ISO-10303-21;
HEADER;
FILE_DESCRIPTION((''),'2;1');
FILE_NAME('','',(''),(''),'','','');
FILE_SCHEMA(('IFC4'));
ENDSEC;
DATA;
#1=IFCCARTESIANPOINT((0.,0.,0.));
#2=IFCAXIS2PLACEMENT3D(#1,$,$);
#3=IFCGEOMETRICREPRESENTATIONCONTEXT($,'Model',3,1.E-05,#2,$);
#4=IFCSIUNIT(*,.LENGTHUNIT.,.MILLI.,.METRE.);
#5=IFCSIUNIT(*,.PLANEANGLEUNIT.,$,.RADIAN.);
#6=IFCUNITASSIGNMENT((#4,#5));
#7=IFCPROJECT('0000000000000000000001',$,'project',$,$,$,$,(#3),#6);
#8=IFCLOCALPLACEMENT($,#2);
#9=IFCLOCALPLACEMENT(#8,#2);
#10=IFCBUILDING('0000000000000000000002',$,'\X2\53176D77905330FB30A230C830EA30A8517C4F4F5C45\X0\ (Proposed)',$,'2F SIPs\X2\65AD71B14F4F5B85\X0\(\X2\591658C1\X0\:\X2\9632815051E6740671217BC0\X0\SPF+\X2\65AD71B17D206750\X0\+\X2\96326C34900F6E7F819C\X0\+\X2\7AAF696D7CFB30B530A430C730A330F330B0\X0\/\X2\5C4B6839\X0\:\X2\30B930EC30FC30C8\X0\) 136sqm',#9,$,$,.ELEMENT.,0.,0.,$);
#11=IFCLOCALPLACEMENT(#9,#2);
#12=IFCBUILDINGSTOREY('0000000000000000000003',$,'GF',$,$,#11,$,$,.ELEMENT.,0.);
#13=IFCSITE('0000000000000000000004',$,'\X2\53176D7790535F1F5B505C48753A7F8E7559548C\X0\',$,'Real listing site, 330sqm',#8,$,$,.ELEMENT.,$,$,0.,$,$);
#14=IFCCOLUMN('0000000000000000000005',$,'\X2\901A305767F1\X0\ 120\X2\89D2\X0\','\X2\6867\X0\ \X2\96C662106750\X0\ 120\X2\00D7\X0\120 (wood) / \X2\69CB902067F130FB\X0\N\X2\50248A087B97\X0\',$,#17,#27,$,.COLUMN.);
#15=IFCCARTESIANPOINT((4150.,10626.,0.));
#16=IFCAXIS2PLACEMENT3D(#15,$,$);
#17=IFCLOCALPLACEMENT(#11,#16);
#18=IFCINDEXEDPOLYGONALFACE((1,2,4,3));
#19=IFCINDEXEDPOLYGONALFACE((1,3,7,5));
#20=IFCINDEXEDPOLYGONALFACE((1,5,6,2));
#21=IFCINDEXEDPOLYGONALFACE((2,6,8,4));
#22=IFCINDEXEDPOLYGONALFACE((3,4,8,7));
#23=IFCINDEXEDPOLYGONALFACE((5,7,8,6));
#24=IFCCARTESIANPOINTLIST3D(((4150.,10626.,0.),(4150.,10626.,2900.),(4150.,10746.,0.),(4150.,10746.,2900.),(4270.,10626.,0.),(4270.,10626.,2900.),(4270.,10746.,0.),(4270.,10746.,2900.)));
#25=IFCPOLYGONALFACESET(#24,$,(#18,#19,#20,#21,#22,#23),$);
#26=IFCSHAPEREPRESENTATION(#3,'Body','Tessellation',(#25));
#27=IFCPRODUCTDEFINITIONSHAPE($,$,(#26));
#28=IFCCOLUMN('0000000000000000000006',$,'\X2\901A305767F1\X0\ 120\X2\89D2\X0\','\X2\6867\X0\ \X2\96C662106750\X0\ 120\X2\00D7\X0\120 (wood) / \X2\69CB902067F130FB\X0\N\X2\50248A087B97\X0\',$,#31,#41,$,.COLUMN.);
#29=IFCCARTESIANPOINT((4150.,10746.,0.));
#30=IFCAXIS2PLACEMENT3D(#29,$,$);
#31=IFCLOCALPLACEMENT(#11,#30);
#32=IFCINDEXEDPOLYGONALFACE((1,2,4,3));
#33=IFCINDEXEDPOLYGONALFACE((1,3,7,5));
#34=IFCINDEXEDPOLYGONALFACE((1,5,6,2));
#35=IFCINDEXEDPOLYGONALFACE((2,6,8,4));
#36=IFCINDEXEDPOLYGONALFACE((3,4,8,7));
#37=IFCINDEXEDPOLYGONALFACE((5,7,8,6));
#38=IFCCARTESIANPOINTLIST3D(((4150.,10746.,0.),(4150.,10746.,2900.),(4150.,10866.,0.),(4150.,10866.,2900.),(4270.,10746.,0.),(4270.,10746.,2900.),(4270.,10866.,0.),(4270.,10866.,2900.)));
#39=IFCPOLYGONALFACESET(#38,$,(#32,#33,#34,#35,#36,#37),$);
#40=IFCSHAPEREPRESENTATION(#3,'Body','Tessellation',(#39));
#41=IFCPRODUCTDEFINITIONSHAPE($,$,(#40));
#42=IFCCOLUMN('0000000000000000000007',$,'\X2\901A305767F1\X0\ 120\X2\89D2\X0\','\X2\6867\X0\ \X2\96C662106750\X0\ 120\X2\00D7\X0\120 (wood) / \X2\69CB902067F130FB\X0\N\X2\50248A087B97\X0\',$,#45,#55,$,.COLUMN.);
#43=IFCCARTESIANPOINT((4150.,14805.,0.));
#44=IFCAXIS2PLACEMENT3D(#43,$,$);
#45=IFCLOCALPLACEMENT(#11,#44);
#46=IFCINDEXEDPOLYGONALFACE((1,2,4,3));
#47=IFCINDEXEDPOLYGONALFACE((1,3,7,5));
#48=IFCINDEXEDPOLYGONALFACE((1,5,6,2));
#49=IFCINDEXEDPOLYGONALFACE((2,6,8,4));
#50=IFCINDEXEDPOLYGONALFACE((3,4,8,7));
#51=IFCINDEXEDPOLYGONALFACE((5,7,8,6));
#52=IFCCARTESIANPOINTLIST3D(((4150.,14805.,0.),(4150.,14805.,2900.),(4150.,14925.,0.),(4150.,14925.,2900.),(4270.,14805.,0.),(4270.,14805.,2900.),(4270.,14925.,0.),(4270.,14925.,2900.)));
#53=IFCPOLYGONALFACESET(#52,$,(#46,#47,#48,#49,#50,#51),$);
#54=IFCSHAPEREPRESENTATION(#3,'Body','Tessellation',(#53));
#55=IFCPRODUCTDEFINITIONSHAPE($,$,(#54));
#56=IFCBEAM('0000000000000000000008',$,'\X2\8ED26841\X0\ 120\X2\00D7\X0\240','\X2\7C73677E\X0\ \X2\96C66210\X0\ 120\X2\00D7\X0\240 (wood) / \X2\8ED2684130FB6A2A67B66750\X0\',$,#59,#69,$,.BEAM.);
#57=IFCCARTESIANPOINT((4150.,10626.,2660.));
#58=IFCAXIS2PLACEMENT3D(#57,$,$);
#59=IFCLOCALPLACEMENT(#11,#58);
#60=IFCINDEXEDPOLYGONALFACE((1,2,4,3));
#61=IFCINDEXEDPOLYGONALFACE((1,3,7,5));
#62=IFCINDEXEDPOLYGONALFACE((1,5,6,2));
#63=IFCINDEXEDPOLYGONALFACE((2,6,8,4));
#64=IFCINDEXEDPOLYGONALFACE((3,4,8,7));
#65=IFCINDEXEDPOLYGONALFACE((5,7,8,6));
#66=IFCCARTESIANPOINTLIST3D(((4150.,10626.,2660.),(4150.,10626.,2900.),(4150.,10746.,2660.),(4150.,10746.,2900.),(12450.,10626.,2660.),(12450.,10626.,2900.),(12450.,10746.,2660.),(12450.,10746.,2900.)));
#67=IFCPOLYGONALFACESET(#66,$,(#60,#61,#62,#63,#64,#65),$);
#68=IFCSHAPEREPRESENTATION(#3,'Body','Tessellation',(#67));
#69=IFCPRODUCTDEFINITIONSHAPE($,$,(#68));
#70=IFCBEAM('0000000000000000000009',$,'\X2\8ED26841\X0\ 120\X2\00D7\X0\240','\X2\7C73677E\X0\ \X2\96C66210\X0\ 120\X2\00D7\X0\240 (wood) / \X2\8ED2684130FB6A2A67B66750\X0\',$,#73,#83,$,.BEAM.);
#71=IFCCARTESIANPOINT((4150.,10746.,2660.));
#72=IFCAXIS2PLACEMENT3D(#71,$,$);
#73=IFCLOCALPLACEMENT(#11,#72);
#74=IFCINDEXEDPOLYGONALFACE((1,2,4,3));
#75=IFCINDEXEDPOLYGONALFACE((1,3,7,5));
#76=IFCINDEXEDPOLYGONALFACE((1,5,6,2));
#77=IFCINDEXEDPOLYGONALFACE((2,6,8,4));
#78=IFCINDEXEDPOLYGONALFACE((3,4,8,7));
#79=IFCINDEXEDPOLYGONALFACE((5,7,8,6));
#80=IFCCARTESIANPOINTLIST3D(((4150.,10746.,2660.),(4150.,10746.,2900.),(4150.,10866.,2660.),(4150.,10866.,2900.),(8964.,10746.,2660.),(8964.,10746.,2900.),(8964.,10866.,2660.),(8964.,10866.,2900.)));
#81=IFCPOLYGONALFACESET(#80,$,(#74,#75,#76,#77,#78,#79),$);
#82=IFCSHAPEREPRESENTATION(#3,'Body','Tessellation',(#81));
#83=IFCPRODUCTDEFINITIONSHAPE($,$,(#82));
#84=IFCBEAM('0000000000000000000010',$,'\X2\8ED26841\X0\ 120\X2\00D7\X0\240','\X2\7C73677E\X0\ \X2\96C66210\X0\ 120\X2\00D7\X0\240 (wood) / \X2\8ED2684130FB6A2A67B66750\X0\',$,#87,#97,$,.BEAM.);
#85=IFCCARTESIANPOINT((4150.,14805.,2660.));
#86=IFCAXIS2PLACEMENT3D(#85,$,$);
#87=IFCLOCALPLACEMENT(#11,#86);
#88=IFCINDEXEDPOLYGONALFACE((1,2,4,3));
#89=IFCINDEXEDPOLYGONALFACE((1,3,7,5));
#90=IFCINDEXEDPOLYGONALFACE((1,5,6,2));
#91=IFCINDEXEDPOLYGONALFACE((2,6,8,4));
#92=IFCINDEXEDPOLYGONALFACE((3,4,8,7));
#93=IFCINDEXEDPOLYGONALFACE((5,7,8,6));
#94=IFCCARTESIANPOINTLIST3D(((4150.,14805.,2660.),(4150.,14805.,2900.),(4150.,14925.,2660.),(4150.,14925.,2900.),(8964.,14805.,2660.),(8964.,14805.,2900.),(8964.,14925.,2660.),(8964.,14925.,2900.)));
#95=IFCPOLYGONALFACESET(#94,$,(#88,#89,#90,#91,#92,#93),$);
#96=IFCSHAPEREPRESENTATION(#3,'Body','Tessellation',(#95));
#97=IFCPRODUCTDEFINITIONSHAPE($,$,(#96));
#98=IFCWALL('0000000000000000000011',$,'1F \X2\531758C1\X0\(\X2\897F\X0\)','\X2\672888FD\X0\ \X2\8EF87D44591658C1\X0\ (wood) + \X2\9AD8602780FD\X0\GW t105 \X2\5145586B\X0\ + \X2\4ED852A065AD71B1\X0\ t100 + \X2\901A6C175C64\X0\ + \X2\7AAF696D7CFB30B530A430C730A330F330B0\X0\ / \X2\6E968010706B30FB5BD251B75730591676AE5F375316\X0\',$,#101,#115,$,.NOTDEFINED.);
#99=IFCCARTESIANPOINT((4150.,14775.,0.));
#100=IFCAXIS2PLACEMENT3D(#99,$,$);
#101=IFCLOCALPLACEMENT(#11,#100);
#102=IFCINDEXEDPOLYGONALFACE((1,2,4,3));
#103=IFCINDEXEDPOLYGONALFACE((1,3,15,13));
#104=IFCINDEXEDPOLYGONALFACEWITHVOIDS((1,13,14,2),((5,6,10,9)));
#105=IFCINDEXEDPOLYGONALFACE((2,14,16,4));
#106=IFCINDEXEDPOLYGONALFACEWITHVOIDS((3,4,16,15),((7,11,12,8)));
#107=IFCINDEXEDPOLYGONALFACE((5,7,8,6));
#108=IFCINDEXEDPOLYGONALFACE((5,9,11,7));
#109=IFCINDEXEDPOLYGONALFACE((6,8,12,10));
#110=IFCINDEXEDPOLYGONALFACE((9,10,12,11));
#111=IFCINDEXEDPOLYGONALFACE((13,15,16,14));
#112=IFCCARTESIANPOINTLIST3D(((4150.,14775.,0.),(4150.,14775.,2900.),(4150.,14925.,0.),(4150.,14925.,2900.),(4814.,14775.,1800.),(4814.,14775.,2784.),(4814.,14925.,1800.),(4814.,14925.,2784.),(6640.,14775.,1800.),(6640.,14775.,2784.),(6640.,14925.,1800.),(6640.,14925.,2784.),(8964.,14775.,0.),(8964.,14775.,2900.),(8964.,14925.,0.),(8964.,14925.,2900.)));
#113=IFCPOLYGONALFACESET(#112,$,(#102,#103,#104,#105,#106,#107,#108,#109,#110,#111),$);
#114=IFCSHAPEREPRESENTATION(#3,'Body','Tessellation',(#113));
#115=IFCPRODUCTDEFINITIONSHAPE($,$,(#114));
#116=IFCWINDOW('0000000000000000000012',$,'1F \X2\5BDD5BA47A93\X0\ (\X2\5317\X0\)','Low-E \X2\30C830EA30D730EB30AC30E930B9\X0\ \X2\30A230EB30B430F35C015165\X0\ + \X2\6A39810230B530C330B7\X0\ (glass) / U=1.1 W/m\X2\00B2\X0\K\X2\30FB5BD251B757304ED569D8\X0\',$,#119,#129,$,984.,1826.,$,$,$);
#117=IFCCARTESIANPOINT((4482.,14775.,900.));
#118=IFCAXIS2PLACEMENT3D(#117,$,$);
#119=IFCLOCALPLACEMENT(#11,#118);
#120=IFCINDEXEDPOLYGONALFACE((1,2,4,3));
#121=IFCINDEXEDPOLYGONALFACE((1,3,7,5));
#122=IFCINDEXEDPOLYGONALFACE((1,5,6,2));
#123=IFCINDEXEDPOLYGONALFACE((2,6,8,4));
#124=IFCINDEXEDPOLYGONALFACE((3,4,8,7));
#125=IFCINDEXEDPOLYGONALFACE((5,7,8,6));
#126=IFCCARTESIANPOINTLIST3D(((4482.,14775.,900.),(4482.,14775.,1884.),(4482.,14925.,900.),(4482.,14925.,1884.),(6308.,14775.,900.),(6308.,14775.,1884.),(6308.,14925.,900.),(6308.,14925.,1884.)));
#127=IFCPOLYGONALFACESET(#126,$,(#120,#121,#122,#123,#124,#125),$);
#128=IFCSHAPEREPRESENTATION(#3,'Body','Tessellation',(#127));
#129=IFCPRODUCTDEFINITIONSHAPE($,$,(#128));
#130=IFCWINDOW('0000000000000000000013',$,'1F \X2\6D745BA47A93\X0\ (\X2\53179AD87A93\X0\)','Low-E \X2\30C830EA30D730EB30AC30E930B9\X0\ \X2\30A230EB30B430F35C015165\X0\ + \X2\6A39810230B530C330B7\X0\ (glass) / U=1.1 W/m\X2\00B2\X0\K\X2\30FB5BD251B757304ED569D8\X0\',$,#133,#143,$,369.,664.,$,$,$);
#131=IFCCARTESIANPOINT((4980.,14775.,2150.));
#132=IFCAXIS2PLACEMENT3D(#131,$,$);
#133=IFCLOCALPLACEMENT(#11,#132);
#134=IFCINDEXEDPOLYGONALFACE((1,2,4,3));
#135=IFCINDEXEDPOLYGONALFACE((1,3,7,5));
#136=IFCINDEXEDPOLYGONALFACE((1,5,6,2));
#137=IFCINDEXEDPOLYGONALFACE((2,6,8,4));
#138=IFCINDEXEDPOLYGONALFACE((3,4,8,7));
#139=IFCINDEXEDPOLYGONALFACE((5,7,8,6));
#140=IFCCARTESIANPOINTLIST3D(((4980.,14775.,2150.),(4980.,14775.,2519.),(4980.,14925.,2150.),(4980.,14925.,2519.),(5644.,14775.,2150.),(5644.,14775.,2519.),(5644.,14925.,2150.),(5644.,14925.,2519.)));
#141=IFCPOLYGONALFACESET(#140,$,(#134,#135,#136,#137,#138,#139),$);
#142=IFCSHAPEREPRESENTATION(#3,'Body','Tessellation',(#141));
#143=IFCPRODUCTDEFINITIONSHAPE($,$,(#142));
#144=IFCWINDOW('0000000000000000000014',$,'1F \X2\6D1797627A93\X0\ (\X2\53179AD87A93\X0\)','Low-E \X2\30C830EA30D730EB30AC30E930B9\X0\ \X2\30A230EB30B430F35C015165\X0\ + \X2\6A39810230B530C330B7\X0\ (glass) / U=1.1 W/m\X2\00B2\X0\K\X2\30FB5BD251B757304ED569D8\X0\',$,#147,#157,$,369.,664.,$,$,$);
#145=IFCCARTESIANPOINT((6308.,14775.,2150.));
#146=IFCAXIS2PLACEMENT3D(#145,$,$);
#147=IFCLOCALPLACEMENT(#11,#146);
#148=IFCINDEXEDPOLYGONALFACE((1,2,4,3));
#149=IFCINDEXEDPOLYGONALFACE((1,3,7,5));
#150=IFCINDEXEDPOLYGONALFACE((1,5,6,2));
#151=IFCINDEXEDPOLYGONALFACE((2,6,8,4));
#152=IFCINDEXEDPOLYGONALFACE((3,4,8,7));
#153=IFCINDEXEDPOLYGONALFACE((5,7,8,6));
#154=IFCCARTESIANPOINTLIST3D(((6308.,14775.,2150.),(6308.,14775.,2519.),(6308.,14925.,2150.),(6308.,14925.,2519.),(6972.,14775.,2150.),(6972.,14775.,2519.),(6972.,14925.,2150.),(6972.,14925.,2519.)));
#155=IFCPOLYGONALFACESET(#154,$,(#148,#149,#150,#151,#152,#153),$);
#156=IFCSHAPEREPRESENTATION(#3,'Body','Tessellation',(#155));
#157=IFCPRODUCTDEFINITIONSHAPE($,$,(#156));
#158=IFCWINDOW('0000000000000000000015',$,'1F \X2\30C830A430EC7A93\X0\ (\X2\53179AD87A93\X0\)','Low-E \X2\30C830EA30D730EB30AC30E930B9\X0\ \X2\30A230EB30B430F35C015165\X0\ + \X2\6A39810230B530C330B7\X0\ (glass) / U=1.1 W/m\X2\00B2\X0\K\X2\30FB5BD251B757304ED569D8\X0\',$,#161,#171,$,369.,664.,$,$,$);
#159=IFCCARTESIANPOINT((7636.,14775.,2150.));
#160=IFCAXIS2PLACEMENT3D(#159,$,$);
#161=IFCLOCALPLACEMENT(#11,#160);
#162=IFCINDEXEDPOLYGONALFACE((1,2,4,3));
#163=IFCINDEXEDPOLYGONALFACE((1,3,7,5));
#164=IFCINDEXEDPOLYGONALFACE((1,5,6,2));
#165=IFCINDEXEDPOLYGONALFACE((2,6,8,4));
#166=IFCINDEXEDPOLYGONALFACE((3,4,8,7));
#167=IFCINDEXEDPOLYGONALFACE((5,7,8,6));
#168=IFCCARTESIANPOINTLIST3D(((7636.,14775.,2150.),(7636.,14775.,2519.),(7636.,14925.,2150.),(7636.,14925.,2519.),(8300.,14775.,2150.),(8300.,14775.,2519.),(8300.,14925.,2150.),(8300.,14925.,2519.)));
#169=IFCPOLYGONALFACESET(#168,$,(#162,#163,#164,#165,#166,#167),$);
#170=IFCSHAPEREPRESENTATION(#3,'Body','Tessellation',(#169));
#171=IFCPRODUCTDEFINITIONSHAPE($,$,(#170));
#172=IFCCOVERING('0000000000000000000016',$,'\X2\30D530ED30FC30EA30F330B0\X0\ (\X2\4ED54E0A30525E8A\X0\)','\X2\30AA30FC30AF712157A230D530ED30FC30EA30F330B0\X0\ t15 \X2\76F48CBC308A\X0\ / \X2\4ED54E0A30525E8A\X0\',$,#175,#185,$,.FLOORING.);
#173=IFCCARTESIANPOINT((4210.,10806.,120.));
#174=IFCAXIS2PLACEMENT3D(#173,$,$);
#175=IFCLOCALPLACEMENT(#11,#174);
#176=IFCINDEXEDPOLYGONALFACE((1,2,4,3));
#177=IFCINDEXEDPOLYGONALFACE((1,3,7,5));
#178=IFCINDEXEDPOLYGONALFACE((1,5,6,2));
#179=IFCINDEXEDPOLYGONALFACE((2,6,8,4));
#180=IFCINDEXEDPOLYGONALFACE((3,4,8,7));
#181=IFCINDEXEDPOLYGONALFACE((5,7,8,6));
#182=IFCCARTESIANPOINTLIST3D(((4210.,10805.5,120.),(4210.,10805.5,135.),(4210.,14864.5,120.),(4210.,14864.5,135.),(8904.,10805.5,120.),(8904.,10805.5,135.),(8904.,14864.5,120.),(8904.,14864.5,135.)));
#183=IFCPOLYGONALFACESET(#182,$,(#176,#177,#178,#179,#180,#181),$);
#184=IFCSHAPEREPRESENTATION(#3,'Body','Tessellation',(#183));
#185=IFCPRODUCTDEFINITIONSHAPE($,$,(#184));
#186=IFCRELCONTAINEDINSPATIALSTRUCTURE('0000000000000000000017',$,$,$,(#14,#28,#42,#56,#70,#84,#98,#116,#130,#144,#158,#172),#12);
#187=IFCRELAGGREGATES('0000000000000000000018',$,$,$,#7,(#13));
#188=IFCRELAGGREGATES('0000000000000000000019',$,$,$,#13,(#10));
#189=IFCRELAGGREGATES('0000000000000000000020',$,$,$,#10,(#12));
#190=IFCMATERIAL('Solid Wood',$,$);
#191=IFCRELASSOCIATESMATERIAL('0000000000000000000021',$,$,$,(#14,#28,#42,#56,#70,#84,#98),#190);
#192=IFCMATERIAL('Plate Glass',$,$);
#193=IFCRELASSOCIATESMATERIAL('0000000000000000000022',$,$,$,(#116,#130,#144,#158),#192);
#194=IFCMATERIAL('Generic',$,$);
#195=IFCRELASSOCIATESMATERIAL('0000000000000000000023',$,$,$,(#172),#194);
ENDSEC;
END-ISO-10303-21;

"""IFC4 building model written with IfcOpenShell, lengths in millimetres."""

from ifc_helpers import new_model, si_unit, frame, frame_2d, origin, place, context, project, spatial, rectangle, extrude, material, element, fill, save


model = new_model("IFC4")

# Units and contexts
model_context = context("Model", 3, precision=1e-05, world=origin())
ifc_project = project(units=[si_unit("LENGTHUNIT", "METRE", prefix="MILLI"), si_unit("PLANEANGLEUNIT", "RADIAN")], contexts=[model_context])

# Site, building, storey
site_placement = place(None, origin())
site = spatial("IfcSite", under=ifc_project, at=site_placement, Name="北海道弟子屈町美留和", ObjectType="Real listing site, 330sqm", CompositionType="ELEMENT", RefElevation=0.0)
building_placement = place(site_placement, origin())
building = spatial("IfcBuilding", under=site, at=building_placement, Name="北海道・アトリエ兼住居 (Proposed)", ObjectType="2F SIPs断熱住宅(外壁:防腐処理無節SPF+断熱素材+防水透湿膜+窯業系サイディング/屋根:スレート) 136sqm", CompositionType="ELEMENT", ElevationOfRefHeight=0.0, ElevationOfTerrain=0.0)
storey_placement = place(building_placement, origin())
storey = spatial("IfcBuildingStorey", under=building, at=storey_placement, Name="GF", CompositionType="ELEMENT", Elevation=0.0)

# Columns
ifc_material_1 = material(Name="Solid Wood")
column_1_placement = place(storey_placement, frame((4150.0, 10626.0, 0.0)))
element("IfcColumn", 1, at=column_1_placement, inside=storey, material=ifc_material_1, Name="通し柱 120角", Description="桧 集成材 120×120 (wood) / 構造柱・N値計算", PredefinedType="COLUMN", context=model_context, shape_type="SweptSolid", body=[
    extrude(rectangle(XDim=120.0, YDim=120.0, at=frame_2d((60.0, 60.0))), frame((4150.0, 10626.0, 0.0)), (0.0, 0.0, 1.0), 2900.0),
])
column_2_placement = place(storey_placement, frame((4150.0, 10746.0, 0.0)))
element("IfcColumn", 2, at=column_2_placement, inside=storey, material=ifc_material_1, Name="通し柱 120角", Description="桧 集成材 120×120 (wood) / 構造柱・N値計算", PredefinedType="COLUMN", context=model_context, shape_type="SweptSolid", body=[
    extrude(rectangle(XDim=120.0, YDim=120.0, at=frame_2d((60.0, 60.0))), frame((4150.0, 10746.0, 0.0)), (0.0, 0.0, 1.0), 2900.0),
])
column_3_placement = place(storey_placement, frame((4150.0, 14805.0, 0.0)))
element("IfcColumn", 3, at=column_3_placement, inside=storey, material=ifc_material_1, Name="通し柱 120角", Description="桧 集成材 120×120 (wood) / 構造柱・N値計算", PredefinedType="COLUMN", context=model_context, shape_type="SweptSolid", body=[
    extrude(rectangle(XDim=120.0, YDim=120.0, at=frame_2d((60.0, 60.0))), frame((4150.0, 14805.0, 0.0)), (0.0, 0.0, 1.0), 2900.0),
])

# Beams
beam_1_placement = place(storey_placement, frame((4150.0, 10626.0, 2660.0)))
element("IfcBeam", 4, at=beam_1_placement, inside=storey, material=ifc_material_1, Name="軒桁 120×240", Description="米松 集成 120×240 (wood) / 軒桁・横架材", PredefinedType="BEAM", context=model_context, shape_type="SweptSolid", body=[
    extrude(rectangle(XDim=8300.0, YDim=120.0, at=frame_2d((4150.0, 60.0))), frame((4150.0, 10626.0, 2660.0)), (0.0, 0.0, 1.0), 240.0),
])
beam_2_placement = place(storey_placement, frame((4150.0, 10746.0, 2660.0)))
element("IfcBeam", 5, at=beam_2_placement, inside=storey, material=ifc_material_1, Name="軒桁 120×240", Description="米松 集成 120×240 (wood) / 軒桁・横架材", PredefinedType="BEAM", context=model_context, shape_type="SweptSolid", body=[
    extrude(rectangle(XDim=4814.0, YDim=120.0, at=frame_2d((2407.0, 60.0))), frame((4150.0, 10746.0, 2660.0)), (0.0, 0.0, 1.0), 240.0),
])
beam_3_placement = place(storey_placement, frame((4150.0, 14805.0, 2660.0)))
element("IfcBeam", 6, at=beam_3_placement, inside=storey, material=ifc_material_1, Name="軒桁 120×240", Description="米松 集成 120×240 (wood) / 軒桁・横架材", PredefinedType="BEAM", context=model_context, shape_type="SweptSolid", body=[
    extrude(rectangle(XDim=4814.0, YDim=120.0, at=frame_2d((2407.0, 60.0))), frame((4150.0, 14805.0, 2660.0)), (0.0, 0.0, 1.0), 240.0),
])

# Wall, openings, windows
wall_1_placement = place(storey_placement, frame((4150.0, 14775.0, 0.0)))
wall_1 = element("IfcWall", 7, at=wall_1_placement, inside=storey, material=ifc_material_1, Name="1F 北壁(西)", Description="木製 軸組外壁 (wood) + 高性能GW t105 充填 + 付加断熱 t100 + 通気層 + 窯業系サイディング / 準耐火・寒冷地外皮強化", PredefinedType="NOTDEFINED", context=model_context, shape_type="SweptSolid", body=[
    extrude(rectangle(XDim=4814.0, YDim=150.0, at=frame_2d((2407.0, 75.0))), frame((4150.0, 14775.0, 0.0)), (0.0, 0.0, 1.0), 2900.0),
])
opening_1_placement = place(storey_placement, frame((4482.0, 14775.0, 900.0)))
opening_1 = element("IfcOpeningElement", 8, at=opening_1_placement, cuts=wall_1, PredefinedType="NOTDEFINED", context=model_context, shape_type="SweptSolid", body=[
    extrude(rectangle(XDim=1826.0, YDim=150.0, at=frame_2d((913.0, 75.0))), frame((4482.0, 14775.0, 900.0)), (0.0, 0.0, 1.0), 984.0),
])
opening_2_placement = place(storey_placement, frame((4980.0, 14775.0, 2150.0)))
opening_2 = element("IfcOpeningElement", 9, at=opening_2_placement, cuts=wall_1, PredefinedType="NOTDEFINED", context=model_context, shape_type="SweptSolid", body=[
    extrude(rectangle(XDim=664.0, YDim=150.0, at=frame_2d((332.0, 75.0))), frame((4980.0, 14775.0, 2150.0)), (0.0, 0.0, 1.0), 369.0),
])
opening_3_placement = place(storey_placement, frame((6308.0, 14775.0, 2150.0)))
opening_3 = element("IfcOpeningElement", 10, at=opening_3_placement, cuts=wall_1, PredefinedType="NOTDEFINED", context=model_context, shape_type="SweptSolid", body=[
    extrude(rectangle(XDim=664.0, YDim=150.0, at=frame_2d((332.0, 75.0))), frame((6308.0, 14775.0, 2150.0)), (0.0, 0.0, 1.0), 369.0),
])
opening_4_placement = place(storey_placement, frame((7636.0, 14775.0, 2150.0)))
opening_4 = element("IfcOpeningElement", 11, at=opening_4_placement, cuts=wall_1, PredefinedType="NOTDEFINED", context=model_context, shape_type="SweptSolid", body=[
    extrude(rectangle(XDim=664.0, YDim=150.0, at=frame_2d((332.0, 75.0))), frame((7636.0, 14775.0, 2150.0)), (0.0, 0.0, 1.0), 369.0),
])
ifc_material_2 = material(Name="Plate Glass")
window_1_placement = place(storey_placement, frame((4482.0, 14775.0, 900.0)))
window_1 = element("IfcWindow", 12, at=window_1_placement, inside=storey, material=ifc_material_2, Name="1F 寝室窓 (北)", Description="Low-E トリプルガラス アルゴン封入 + 樹脂サッシ (glass) / U=1.1 W/m²K・寒冷地仕様", OverallHeight=984.0, OverallWidth=1826.0, context=model_context, shape_type="SweptSolid", body=[
    extrude(rectangle(XDim=1826.0, YDim=150.0, at=frame_2d((913.0, 75.0))), frame((4482.0, 14775.0, 900.0)), (0.0, 0.0, 1.0), 984.0),
])
fill(opening_1, window_1)
window_2_placement = place(storey_placement, frame((4980.0, 14775.0, 2150.0)))
window_2 = element("IfcWindow", 13, at=window_2_placement, inside=storey, material=ifc_material_2, Name="1F 浴室窓 (北高窓)", Description="Low-E トリプルガラス アルゴン封入 + 樹脂サッシ (glass) / U=1.1 W/m²K・寒冷地仕様", OverallHeight=369.0, OverallWidth=664.0, context=model_context, shape_type="SweptSolid", body=[
    extrude(rectangle(XDim=664.0, YDim=150.0, at=frame_2d((332.0, 75.0))), frame((4980.0, 14775.0, 2150.0)), (0.0, 0.0, 1.0), 369.0),
])
fill(opening_2, window_2)
window_3_placement = place(storey_placement, frame((6308.0, 14775.0, 2150.0)))
window_3 = element("IfcWindow", 14, at=window_3_placement, inside=storey, material=ifc_material_2, Name="1F 洗面窓 (北高窓)", Description="Low-E トリプルガラス アルゴン封入 + 樹脂サッシ (glass) / U=1.1 W/m²K・寒冷地仕様", OverallHeight=369.0, OverallWidth=664.0, context=model_context, shape_type="SweptSolid", body=[
    extrude(rectangle(XDim=664.0, YDim=150.0, at=frame_2d((332.0, 75.0))), frame((6308.0, 14775.0, 2150.0)), (0.0, 0.0, 1.0), 369.0),
])
fill(opening_3, window_3)
window_4_placement = place(storey_placement, frame((7636.0, 14775.0, 2150.0)))
window_4 = element("IfcWindow", 15, at=window_4_placement, inside=storey, material=ifc_material_2, Name="1F トイレ窓 (北高窓)", Description="Low-E トリプルガラス アルゴン封入 + 樹脂サッシ (glass) / U=1.1 W/m²K・寒冷地仕様", OverallHeight=369.0, OverallWidth=664.0, context=model_context, shape_type="SweptSolid", body=[
    extrude(rectangle(XDim=664.0, YDim=150.0, at=frame_2d((332.0, 75.0))), frame((7636.0, 14775.0, 2150.0)), (0.0, 0.0, 1.0), 369.0),
])
fill(opening_4, window_4)

# Covering
ifc_material_3 = material(Name="Generic")
covering_placement = place(storey_placement, frame((4210.0, 10806.0, 120.0)))
element("IfcCovering", 16, at=covering_placement, inside=storey, material=ifc_material_3, Name="フローリング (仕上げ床)", Description="オーク無垢フローリング t15 直貼り / 仕上げ床", PredefinedType="FLOORING", context=model_context, shape_type="SweptSolid", body=[
    extrude(rectangle(XDim=4694.0, YDim=4059.0, at=frame_2d((2347.0, 2029.0))), frame((4210.0, 10806.0, 120.0)), (0.0, 0.0, 1.0), 15.0),
])

save(model, "model.ifc")
